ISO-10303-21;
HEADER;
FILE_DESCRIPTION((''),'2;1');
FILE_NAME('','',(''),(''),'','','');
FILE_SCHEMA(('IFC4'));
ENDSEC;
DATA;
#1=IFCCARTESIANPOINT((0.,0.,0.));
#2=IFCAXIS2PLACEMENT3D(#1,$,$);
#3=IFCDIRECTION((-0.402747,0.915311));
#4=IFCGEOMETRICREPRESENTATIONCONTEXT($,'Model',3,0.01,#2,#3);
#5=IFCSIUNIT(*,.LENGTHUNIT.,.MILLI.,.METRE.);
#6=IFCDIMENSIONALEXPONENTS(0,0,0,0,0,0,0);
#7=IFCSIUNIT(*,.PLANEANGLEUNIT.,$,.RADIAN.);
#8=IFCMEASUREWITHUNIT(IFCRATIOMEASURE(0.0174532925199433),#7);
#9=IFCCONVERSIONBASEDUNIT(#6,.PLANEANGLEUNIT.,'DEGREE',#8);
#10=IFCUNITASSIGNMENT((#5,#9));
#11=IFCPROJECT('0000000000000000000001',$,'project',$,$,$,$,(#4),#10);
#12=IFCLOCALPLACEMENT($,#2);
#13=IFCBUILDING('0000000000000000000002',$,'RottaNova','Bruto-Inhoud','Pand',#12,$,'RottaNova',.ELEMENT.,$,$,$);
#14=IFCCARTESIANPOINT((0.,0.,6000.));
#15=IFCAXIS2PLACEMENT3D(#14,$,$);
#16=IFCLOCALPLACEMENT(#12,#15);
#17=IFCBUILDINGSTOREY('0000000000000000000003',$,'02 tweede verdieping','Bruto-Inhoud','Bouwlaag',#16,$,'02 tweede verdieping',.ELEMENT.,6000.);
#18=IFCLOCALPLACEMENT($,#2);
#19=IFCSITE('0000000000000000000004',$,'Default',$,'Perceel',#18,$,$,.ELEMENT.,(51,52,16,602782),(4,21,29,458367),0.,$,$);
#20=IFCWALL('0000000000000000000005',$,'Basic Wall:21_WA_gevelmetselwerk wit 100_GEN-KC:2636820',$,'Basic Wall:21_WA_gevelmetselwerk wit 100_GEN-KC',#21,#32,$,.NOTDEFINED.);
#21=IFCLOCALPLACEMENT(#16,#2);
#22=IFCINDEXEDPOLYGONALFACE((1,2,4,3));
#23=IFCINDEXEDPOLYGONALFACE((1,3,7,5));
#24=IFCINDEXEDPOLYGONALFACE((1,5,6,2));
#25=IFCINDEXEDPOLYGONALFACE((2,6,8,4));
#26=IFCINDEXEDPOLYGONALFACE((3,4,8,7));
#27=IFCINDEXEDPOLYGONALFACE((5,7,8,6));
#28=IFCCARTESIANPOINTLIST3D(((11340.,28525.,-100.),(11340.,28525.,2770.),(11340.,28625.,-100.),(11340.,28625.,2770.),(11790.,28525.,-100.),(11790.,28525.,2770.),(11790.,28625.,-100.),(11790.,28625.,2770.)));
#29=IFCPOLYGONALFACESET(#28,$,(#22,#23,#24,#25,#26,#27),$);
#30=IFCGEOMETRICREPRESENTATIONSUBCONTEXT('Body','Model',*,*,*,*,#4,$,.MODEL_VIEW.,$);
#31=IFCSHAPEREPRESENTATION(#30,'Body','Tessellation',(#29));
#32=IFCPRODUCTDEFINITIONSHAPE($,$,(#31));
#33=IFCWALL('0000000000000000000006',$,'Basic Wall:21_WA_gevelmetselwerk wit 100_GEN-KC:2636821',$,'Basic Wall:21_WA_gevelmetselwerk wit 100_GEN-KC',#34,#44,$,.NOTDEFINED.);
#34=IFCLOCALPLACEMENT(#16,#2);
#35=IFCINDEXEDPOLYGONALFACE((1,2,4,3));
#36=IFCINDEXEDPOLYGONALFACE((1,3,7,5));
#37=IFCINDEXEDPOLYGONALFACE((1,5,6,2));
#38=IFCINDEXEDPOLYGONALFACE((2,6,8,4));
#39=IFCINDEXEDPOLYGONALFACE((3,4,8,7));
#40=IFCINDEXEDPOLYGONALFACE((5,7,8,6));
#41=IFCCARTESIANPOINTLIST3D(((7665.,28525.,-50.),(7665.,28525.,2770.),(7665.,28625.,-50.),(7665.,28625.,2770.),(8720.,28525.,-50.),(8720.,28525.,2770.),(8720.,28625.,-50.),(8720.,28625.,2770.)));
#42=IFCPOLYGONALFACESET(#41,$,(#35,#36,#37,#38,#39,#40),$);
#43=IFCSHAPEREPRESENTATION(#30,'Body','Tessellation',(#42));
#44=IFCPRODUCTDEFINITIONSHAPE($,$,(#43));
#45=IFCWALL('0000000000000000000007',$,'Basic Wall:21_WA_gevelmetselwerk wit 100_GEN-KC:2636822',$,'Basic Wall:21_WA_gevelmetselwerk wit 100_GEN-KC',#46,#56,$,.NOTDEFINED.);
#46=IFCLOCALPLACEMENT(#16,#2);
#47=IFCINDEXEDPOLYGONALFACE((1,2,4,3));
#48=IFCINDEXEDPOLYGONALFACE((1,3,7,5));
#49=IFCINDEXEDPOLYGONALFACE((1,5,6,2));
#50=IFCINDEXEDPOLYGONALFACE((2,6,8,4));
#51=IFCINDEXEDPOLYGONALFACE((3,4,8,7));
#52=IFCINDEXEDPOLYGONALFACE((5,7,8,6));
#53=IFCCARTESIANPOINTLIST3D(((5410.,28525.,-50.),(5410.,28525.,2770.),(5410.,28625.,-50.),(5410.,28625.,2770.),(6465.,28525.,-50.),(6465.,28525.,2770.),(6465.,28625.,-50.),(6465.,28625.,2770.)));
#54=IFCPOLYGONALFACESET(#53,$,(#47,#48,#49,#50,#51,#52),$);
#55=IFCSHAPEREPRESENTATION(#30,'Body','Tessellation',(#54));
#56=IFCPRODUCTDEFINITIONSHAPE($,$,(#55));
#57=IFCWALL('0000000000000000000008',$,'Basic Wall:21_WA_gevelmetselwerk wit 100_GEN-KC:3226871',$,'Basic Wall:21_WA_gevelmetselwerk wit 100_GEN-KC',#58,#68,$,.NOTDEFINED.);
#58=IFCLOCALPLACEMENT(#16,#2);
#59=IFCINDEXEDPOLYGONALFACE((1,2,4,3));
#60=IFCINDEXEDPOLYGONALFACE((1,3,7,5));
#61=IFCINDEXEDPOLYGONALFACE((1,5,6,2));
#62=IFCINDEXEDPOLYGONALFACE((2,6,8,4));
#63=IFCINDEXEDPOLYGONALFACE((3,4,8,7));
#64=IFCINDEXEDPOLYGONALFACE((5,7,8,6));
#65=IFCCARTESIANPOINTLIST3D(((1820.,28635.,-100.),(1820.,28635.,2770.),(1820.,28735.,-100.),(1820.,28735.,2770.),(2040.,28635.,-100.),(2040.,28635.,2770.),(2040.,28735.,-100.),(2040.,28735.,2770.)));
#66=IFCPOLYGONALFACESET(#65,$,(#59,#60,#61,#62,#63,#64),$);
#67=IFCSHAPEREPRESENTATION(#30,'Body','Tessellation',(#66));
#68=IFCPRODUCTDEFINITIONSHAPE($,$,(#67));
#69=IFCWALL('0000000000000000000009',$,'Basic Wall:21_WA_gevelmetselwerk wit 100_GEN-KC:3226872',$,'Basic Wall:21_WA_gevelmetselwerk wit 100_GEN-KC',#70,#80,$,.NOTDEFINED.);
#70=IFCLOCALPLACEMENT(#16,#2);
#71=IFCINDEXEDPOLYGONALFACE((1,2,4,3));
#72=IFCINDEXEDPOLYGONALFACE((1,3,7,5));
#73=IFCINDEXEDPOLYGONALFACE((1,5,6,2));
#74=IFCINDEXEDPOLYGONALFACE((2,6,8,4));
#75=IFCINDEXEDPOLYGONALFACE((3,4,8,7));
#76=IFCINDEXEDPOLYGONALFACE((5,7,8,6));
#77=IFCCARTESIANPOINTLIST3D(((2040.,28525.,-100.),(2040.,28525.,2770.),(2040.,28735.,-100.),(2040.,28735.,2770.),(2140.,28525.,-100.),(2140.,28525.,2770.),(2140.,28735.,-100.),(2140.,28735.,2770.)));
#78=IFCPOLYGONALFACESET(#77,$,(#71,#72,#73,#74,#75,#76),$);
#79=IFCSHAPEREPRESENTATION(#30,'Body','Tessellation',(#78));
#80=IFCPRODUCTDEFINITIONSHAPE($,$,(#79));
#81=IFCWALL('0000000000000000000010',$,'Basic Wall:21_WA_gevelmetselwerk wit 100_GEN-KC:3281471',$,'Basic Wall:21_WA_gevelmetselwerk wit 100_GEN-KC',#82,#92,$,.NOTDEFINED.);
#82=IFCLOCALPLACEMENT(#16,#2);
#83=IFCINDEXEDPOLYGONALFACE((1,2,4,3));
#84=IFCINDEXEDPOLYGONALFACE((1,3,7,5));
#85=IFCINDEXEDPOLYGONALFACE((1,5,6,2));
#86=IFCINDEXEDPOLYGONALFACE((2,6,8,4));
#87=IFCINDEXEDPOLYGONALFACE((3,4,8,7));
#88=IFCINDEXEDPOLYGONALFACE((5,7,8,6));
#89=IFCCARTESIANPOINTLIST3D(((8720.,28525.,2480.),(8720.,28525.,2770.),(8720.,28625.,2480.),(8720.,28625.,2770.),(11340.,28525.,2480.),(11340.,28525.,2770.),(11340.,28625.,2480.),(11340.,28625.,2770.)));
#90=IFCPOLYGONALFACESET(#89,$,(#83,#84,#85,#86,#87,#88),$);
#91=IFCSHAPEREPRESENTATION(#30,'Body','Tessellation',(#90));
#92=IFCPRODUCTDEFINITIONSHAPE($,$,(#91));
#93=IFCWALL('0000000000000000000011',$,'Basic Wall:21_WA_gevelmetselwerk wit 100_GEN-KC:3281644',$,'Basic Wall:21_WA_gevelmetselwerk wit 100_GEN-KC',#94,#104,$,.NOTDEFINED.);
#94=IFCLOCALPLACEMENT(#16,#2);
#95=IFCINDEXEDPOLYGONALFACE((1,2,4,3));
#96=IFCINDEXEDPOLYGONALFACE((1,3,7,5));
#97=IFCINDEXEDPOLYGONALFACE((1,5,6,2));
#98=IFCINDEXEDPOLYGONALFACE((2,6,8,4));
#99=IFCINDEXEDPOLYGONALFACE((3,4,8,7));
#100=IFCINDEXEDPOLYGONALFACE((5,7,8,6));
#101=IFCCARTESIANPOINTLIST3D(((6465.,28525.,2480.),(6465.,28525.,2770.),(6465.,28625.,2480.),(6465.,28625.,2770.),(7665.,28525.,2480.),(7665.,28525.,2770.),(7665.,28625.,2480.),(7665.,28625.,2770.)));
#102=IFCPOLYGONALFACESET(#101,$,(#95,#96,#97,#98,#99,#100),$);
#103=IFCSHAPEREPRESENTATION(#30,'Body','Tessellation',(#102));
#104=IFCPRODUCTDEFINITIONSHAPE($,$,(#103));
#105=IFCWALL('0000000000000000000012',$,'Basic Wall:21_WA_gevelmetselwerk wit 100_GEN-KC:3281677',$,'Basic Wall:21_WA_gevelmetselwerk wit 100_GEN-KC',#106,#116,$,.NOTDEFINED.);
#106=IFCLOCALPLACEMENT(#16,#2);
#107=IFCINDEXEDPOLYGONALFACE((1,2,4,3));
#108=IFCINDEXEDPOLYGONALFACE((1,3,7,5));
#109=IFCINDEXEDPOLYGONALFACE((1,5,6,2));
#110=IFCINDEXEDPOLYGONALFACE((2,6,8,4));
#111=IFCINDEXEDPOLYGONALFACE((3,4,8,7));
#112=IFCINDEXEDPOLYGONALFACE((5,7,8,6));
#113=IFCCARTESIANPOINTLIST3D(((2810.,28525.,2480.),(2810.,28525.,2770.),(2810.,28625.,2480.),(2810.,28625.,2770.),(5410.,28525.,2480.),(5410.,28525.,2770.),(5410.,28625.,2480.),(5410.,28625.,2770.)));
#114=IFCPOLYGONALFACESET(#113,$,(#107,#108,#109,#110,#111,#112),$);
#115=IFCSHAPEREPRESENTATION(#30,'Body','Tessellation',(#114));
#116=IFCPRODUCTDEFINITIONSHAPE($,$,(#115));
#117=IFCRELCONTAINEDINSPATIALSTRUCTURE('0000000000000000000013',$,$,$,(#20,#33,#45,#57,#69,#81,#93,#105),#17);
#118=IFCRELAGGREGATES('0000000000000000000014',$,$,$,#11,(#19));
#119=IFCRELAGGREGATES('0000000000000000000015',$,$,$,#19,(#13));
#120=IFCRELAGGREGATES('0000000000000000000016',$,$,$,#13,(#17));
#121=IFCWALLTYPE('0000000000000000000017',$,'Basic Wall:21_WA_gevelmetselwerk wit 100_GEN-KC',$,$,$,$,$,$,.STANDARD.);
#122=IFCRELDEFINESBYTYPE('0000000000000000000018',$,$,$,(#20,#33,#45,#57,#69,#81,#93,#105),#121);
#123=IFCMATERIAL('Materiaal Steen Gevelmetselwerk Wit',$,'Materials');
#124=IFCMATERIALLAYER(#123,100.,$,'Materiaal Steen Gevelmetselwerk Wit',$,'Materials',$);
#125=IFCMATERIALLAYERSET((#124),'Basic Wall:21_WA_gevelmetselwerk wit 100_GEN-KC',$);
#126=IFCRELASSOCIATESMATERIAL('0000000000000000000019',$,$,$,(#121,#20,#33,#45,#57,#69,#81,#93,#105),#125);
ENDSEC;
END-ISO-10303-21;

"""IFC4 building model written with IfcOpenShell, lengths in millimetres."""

from ifc_helpers import new_model, entity, si_unit, converted_unit, direction, frame, frame_2d, origin, place, context, subcontext, project, spatial, rectangle, extrude, material, layer, layer_set, type_object, element, save


model = new_model("IFC4")

# Units and contexts
model_context = context("Model", 3, precision=0.01, world=origin(), true_north=direction((-0.402747, 0.915311)))
body_context = subcontext(model_context, "Body", "Model", "MODEL_VIEW")
ifc_project = project(units=[si_unit("LENGTHUNIT", "METRE", prefix="MILLI"), converted_unit("PLANEANGLEUNIT", "DEGREE", entity("IfcRatioMeasure", 0.0174532925199433), si_unit("PLANEANGLEUNIT", "RADIAN"), dimensions=[0, 0, 0, 0, 0, 0, 0])], contexts=[model_context])

# Site, building, storey
site_placement = place(None, origin())
site = spatial("IfcSite", under=ifc_project, at=site_placement, Name="Default", ObjectType="Perceel", CompositionType="ELEMENT", RefLatitude=(51, 52, 16, 602782), RefLongitude=(4, 21, 29, 458367), RefElevation=0.0)
building_placement = place(None, origin())
building = spatial("IfcBuilding", under=site, at=building_placement, Name="RottaNova", Description="Bruto-Inhoud", ObjectType="Pand", LongName="RottaNova", CompositionType="ELEMENT")
storey_placement = place(building_placement, frame((0.0, 0.0, 6000.0)))
storey = spatial("IfcBuildingStorey", under=building, at=storey_placement, Name="02 tweede verdieping", Description="Bruto-Inhoud", ObjectType="Bouwlaag", LongName="02 tweede verdieping", CompositionType="ELEMENT", Elevation=6000.0)

# Walls
ifc_material = material(Name="Materiaal Steen Gevelmetselwerk Wit", Category="Materials")
ifc_layer = layer(ifc_material, 100.0, Name="Materiaal Steen Gevelmetselwerk Wit", Category="Materials")
ifc_layer_set = layer_set([ifc_layer], Name="Basic Wall:21_WA_gevelmetselwerk wit 100_GEN-KC")
wall_type = type_object("IfcWallType", Name="Basic Wall:21_WA_gevelmetselwerk wit 100_GEN-KC", PredefinedType="STANDARD", material=ifc_layer_set)
wall_1_placement = place(storey_placement, frame((11340.0, 28575.0, -100.0)))
element("IfcWall", 1, at=wall_1_placement, inside=storey, type_object=wall_type, material=ifc_layer_set, Name="Basic Wall:21_WA_gevelmetselwerk wit 100_GEN-KC:2636820", ObjectType="Basic Wall:21_WA_gevelmetselwerk wit 100_GEN-KC", PredefinedType="NOTDEFINED", context=body_context, shape_type="SweptSolid", body=[
    extrude(rectangle(XDim=450.0, YDim=100.0, at=frame_2d((225.0, 0.0), x_axis=(-1.0, 0.0))), origin(), (0.0, 0.0, 1.0), 2870.0),
])
wall_2_placement = place(storey_placement, frame((7665.0, 28575.0, -50.0)))
element("IfcWall", 2, at=wall_2_placement, inside=storey, type_object=wall_type, material=ifc_layer_set, Name="Basic Wall:21_WA_gevelmetselwerk wit 100_GEN-KC:2636821", ObjectType="Basic Wall:21_WA_gevelmetselwerk wit 100_GEN-KC", PredefinedType="NOTDEFINED", context=body_context, shape_type="SweptSolid", body=[
    extrude(rectangle(XDim=1055.0, YDim=100.0, at=frame_2d((527.5, 0.0), x_axis=(-1.0, 0.0))), origin(), (0.0, 0.0, 1.0), 2820.0),
])
wall_3_placement = place(storey_placement, frame((5410.0, 28575.0, -50.0)))
element("IfcWall", 3, at=wall_3_placement, inside=storey, type_object=wall_type, material=ifc_layer_set, Name="Basic Wall:21_WA_gevelmetselwerk wit 100_GEN-KC:2636822", ObjectType="Basic Wall:21_WA_gevelmetselwerk wit 100_GEN-KC", PredefinedType="NOTDEFINED", context=body_context, shape_type="SweptSolid", body=[
    extrude(rectangle(XDim=1055.0, YDim=100.0, at=frame_2d((527.5, 0.0), x_axis=(-1.0, 0.0))), origin(), (0.0, 0.0, 1.0), 2820.0),
])
wall_4_placement = place(storey_placement, frame((2040.0, 28685.0, -100.0), z_axis=(0.0, 0.0, 1.0), x_axis=(-1.0, 0.0, 0.0)))
element("IfcWall", 4, at=wall_4_placement, inside=storey, type_object=wall_type, material=ifc_layer_set, Name="Basic Wall:21_WA_gevelmetselwerk wit 100_GEN-KC:3226871", ObjectType="Basic Wall:21_WA_gevelmetselwerk wit 100_GEN-KC", PredefinedType="NOTDEFINED", context=body_context, shape_type="SweptSolid", body=[
    extrude(rectangle(XDim=220.0, YDim=100.0, at=frame_2d((110.0, 0.0), x_axis=(-1.0, 0.0))), origin(), (0.0, 0.0, 1.0), 2870.0),
])
wall_5_placement = place(storey_placement, frame((2090.0, 28735.0, -100.0), z_axis=(0.0, 0.0, 1.0), x_axis=(0.0, -1.0, 0.0)))
element("IfcWall", 5, at=wall_5_placement, inside=storey, type_object=wall_type, material=ifc_layer_set, Name="Basic Wall:21_WA_gevelmetselwerk wit 100_GEN-KC:3226872", ObjectType="Basic Wall:21_WA_gevelmetselwerk wit 100_GEN-KC", PredefinedType="NOTDEFINED", context=body_context, shape_type="SweptSolid", body=[
    extrude(rectangle(XDim=210.0, YDim=100.0, at=frame_2d((105.0, 0.0), x_axis=(-1.0, 0.0))), origin(), (0.0, 0.0, 1.0), 2870.0),
])
wall_6_placement = place(storey_placement, frame((11340.0, 28575.0, 2480.0), z_axis=(0.0, 0.0, 1.0), x_axis=(-1.0, 0.0, 0.0)))
element("IfcWall", 6, at=wall_6_placement, inside=storey, type_object=wall_type, material=ifc_layer_set, Name="Basic Wall:21_WA_gevelmetselwerk wit 100_GEN-KC:3281471", ObjectType="Basic Wall:21_WA_gevelmetselwerk wit 100_GEN-KC", PredefinedType="NOTDEFINED", context=body_context, shape_type="SweptSolid", body=[
    extrude(rectangle(XDim=2620.0, YDim=100.0, at=frame_2d((1310.0, 0.0), x_axis=(-1.0, 0.0))), origin(), (0.0, 0.0, 1.0), 290.0),
])
wall_7_placement = place(storey_placement, frame((7665.0, 28575.0, 2480.0), z_axis=(0.0, 0.0, 1.0), x_axis=(-1.0, 0.0, 0.0)))
element("IfcWall", 7, at=wall_7_placement, inside=storey, type_object=wall_type, material=ifc_layer_set, Name="Basic Wall:21_WA_gevelmetselwerk wit 100_GEN-KC:3281644", ObjectType="Basic Wall:21_WA_gevelmetselwerk wit 100_GEN-KC", PredefinedType="NOTDEFINED", context=body_context, shape_type="SweptSolid", body=[
    extrude(rectangle(XDim=1200.0, YDim=100.0, at=frame_2d((600.0, 0.0), x_axis=(-1.0, 0.0))), origin(), (0.0, 0.0, 1.0), 290.0),
])
wall_8_placement = place(storey_placement, frame((5410.0, 28575.0, 2480.0), z_axis=(0.0, 0.0, 1.0), x_axis=(-1.0, 0.0, 0.0)))
element("IfcWall", 8, at=wall_8_placement, inside=storey, type_object=wall_type, material=ifc_layer_set, Name="Basic Wall:21_WA_gevelmetselwerk wit 100_GEN-KC:3281677", ObjectType="Basic Wall:21_WA_gevelmetselwerk wit 100_GEN-KC", PredefinedType="NOTDEFINED", context=body_context, shape_type="SweptSolid", body=[
    extrude(rectangle(XDim=2600.0, YDim=100.0, at=frame_2d((1300.0, 0.0), x_axis=(-1.0, 0.0))), origin(), (0.0, 0.0, 1.0), 290.0),
])

save(model, "model.ifc")
